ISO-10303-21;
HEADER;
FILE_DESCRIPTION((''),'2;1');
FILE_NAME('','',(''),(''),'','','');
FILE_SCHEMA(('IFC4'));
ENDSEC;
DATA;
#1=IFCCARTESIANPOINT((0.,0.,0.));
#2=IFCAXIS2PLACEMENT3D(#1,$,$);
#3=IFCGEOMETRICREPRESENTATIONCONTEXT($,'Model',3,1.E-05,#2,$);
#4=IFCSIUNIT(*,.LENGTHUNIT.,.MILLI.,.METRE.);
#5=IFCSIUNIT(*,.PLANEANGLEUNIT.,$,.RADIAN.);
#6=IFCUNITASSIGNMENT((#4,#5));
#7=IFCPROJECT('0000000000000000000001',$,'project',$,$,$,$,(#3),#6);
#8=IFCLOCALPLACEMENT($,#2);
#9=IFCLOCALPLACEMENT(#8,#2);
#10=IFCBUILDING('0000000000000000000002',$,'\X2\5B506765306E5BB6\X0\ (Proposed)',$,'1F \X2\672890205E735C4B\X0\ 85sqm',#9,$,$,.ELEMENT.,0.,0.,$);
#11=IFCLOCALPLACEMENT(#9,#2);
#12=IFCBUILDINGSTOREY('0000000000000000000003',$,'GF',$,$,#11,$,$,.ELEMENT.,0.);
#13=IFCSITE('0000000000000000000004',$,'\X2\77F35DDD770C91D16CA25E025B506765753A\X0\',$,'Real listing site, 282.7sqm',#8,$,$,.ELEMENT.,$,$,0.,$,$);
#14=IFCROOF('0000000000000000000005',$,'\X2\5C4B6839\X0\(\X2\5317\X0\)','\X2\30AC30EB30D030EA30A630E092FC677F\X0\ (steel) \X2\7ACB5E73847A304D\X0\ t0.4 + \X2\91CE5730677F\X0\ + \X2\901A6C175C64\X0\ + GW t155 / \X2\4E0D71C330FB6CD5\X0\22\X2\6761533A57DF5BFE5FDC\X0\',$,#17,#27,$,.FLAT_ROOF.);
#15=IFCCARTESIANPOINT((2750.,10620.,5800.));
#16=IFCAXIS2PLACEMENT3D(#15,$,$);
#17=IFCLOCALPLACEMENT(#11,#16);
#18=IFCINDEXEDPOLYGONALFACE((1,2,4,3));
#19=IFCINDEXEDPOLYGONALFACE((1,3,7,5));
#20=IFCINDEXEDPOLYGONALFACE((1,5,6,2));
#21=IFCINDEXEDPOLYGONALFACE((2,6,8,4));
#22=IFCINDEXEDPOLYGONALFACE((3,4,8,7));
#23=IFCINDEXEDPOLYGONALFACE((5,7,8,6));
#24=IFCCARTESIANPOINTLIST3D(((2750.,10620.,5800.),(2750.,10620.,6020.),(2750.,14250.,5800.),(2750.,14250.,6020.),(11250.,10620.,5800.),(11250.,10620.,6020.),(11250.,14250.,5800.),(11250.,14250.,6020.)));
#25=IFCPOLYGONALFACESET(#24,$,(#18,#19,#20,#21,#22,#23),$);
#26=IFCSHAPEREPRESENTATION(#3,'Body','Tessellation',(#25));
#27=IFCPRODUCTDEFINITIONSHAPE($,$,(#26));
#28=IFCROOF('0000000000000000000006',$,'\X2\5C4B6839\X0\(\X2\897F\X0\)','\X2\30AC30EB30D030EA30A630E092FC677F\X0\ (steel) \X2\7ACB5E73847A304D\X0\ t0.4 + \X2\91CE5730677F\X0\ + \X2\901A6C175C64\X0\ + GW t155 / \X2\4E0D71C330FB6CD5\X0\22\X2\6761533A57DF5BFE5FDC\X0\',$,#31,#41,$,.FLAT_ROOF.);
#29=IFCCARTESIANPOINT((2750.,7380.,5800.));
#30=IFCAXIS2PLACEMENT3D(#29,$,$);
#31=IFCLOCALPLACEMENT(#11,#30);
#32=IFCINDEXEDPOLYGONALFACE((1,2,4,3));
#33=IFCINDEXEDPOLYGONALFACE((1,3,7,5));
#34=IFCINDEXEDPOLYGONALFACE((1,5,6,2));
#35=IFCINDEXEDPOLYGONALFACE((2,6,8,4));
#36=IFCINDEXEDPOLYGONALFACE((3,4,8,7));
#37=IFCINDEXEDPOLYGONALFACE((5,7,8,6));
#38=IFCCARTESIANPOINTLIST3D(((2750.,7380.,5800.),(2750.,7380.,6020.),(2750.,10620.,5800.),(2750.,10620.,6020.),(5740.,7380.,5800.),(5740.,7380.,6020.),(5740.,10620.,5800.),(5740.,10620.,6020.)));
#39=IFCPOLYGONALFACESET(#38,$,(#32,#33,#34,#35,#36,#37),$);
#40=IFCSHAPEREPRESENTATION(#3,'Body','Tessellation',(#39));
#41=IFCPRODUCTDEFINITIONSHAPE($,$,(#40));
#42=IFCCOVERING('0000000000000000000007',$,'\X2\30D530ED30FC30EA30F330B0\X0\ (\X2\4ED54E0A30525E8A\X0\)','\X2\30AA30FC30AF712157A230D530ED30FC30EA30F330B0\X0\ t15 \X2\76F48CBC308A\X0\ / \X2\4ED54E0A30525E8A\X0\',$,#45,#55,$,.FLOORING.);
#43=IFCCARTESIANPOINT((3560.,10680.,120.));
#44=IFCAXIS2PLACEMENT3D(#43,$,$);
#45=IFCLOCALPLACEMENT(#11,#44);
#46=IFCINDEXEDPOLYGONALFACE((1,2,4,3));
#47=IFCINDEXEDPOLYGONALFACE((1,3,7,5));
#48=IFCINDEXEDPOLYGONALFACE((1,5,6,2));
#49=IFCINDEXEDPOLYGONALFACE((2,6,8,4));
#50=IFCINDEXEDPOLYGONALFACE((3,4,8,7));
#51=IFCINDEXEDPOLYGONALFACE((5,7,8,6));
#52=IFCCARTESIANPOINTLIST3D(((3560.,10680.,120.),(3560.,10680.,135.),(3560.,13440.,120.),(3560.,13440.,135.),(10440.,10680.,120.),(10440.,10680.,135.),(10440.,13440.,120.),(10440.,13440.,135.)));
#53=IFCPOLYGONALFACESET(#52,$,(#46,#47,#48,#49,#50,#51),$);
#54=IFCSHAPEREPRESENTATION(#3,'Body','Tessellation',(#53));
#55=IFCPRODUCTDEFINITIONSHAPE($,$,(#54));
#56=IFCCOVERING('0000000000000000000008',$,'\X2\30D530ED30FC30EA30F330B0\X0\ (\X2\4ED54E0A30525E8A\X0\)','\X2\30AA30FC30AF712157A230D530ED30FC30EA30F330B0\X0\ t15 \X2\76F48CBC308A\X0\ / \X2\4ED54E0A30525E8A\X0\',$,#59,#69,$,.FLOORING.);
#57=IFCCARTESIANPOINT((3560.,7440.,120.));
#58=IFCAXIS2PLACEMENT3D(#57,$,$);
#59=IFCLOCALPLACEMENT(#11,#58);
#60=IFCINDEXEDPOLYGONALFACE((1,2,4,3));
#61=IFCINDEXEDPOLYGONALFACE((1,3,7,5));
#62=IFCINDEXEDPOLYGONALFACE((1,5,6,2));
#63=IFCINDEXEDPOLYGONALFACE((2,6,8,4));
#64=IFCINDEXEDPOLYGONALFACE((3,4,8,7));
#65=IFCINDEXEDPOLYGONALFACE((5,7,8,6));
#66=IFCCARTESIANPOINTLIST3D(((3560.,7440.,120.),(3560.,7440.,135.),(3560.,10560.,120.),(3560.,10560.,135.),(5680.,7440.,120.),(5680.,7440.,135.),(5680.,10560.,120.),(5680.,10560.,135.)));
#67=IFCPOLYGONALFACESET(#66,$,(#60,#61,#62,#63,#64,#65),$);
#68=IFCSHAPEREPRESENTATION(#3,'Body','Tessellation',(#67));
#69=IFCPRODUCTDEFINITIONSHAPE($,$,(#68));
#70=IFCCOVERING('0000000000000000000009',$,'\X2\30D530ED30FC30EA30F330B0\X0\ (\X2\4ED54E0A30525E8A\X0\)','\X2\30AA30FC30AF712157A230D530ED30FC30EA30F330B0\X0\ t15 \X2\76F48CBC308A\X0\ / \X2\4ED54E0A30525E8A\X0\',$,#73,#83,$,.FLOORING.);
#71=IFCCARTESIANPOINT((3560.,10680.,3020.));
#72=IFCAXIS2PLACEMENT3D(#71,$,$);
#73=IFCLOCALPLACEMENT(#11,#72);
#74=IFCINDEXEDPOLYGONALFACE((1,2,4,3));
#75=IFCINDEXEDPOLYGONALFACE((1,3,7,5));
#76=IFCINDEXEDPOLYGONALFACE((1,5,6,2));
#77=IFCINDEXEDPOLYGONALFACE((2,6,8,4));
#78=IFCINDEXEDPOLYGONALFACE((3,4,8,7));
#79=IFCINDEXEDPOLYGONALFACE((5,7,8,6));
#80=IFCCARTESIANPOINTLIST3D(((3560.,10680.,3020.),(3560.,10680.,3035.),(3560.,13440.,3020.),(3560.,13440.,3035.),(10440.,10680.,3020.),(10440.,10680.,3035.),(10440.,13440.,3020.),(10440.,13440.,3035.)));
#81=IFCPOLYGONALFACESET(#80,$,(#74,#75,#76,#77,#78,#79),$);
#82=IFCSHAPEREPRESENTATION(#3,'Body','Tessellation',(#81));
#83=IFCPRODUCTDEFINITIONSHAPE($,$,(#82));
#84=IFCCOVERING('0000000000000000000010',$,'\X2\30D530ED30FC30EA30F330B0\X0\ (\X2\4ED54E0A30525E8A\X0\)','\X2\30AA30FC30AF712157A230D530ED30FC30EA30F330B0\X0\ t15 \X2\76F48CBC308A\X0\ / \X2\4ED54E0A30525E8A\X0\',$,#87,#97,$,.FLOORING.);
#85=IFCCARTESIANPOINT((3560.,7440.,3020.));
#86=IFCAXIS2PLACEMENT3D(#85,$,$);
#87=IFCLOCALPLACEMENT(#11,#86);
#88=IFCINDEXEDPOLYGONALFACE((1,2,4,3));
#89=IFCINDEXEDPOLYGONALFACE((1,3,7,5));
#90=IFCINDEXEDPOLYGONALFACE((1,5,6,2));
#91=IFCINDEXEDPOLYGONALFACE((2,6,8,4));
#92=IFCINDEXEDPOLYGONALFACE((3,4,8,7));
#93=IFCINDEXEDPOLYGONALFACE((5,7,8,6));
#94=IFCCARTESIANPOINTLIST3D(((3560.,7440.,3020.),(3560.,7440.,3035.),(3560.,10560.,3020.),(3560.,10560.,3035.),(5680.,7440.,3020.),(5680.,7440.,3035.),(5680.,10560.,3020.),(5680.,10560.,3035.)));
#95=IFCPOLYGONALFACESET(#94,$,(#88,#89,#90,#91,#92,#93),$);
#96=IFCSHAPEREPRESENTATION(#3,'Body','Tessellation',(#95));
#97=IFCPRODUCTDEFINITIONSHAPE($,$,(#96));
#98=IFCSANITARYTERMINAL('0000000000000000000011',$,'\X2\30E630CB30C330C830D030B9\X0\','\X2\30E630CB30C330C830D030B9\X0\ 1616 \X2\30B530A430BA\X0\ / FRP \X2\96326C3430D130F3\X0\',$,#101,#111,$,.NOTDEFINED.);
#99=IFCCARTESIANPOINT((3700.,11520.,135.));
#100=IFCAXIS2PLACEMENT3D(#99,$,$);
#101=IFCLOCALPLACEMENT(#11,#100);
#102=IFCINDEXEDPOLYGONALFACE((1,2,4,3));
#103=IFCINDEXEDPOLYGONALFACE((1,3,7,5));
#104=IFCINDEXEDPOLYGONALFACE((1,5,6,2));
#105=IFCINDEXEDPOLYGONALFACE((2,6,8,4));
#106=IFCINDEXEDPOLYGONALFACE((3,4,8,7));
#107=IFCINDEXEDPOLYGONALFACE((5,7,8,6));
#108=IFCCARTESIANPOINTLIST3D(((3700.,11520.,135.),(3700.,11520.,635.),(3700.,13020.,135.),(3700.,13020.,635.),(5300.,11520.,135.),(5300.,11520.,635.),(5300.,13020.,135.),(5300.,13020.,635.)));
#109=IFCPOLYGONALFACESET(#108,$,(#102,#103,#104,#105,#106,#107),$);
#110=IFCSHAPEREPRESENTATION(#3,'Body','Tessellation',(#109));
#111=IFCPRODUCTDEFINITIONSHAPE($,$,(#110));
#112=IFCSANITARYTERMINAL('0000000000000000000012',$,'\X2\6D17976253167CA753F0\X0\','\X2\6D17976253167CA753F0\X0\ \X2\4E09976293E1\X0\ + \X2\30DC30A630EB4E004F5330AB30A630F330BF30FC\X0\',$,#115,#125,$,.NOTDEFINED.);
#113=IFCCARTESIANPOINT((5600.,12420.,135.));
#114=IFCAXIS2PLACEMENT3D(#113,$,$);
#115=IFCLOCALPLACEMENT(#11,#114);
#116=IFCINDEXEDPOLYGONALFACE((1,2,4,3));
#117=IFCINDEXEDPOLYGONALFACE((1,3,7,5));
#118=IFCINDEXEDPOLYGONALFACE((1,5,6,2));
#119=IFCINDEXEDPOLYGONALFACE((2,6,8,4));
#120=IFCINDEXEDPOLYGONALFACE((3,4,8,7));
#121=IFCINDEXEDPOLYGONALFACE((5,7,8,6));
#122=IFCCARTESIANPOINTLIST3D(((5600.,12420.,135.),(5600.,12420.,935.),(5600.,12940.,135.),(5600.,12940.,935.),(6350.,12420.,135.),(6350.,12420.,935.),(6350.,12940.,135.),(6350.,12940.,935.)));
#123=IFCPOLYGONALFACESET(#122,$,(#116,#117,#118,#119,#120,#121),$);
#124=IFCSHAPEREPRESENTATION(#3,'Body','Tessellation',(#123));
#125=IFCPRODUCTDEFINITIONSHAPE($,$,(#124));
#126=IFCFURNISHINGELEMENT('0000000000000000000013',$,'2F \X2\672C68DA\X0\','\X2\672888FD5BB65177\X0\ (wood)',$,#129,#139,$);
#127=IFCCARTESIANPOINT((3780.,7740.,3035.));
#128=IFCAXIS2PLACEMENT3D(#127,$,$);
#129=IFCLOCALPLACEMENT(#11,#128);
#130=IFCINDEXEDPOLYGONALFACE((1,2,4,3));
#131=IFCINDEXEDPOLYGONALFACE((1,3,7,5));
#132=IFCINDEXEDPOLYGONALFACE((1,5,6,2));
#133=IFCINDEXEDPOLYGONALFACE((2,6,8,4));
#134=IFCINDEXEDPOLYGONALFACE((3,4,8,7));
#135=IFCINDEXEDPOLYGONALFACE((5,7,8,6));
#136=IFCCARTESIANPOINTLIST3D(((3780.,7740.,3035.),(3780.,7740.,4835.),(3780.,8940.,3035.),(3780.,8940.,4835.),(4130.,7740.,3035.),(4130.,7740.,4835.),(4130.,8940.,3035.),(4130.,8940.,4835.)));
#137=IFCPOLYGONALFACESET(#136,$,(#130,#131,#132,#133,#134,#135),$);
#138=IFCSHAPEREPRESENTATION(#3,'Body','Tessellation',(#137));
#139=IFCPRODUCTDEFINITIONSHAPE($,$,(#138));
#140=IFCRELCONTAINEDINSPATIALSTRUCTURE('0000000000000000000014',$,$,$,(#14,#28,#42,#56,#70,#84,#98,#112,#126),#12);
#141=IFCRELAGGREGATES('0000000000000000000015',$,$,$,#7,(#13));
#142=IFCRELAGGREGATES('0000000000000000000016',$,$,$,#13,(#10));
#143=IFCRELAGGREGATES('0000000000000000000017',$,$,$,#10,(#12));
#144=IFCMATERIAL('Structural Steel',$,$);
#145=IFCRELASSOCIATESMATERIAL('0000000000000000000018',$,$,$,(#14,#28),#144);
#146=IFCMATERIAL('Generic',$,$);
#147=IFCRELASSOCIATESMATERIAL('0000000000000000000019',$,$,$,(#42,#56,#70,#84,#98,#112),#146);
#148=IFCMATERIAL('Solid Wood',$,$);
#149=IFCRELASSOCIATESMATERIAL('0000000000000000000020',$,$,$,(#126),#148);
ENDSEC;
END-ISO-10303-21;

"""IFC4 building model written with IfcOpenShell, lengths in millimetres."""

from ifc_helpers import new_model, si_unit, frame, frame_2d, origin, place, context, project, spatial, rectangle, extrude, material, element, save


model = new_model("IFC4")

# Units and contexts
model_context = context("Model", 3, precision=1e-05, world=origin())
ifc_project = project(units=[si_unit("LENGTHUNIT", "METRE", prefix="MILLI"), si_unit("PLANEANGLEUNIT", "RADIAN")], contexts=[model_context])

# Site, building, storey
site_placement = place(None, origin())
site = spatial("IfcSite", under=ifc_project, at=site_placement, Name="石川県金沢市子来町", ObjectType="Real listing site, 282.7sqm", CompositionType="ELEMENT", RefElevation=0.0)
building_placement = place(site_placement, origin())
building = spatial("IfcBuilding", under=site, at=building_placement, Name="子来の家 (Proposed)", ObjectType="1F 木造平屋 85sqm", CompositionType="ELEMENT", ElevationOfRefHeight=0.0, ElevationOfTerrain=0.0)
storey_placement = place(building_placement, origin())
storey = spatial("IfcBuildingStorey", under=building, at=storey_placement, Name="GF", CompositionType="ELEMENT", Elevation=0.0)

# Shared definitions
ifc_material_1 = material(Name="Solid Wood")

# Roofs
ifc_material_2 = material(Name="Structural Steel")
for number, where, name in (
    (1, (2750.0, 10620.0, 5800.0), "屋根(北)"),
):
    element("IfcRoof", number, at=place(storey_placement, frame(where)), inside=storey, material=ifc_material_2, Name=name, Description="ガルバリウム鋼板 (steel) 立平葺き t0.4 + 野地板 + 通気層 + GW t155 / 不燃・法22条区域対応", PredefinedType="FLAT_ROOF", context=model_context, shape_type="SweptSolid", body=[
        extrude(rectangle(XDim=8500.0, YDim=3630.0, at=frame_2d((4250.0, 1815.0))), frame((2750.0, 10620.0, 5800.0)), (0.0, 0.0, 1.0), 220.0),
    ])
roof_placement = place(storey_placement, frame((2750.0, 7380.0, 5800.0)))
element("IfcRoof", 2, at=roof_placement, inside=storey, material=ifc_material_2, Name="屋根(西)", Description="ガルバリウム鋼板 (steel) 立平葺き t0.4 + 野地板 + 通気層 + GW t155 / 不燃・法22条区域対応", PredefinedType="FLAT_ROOF", context=model_context, shape_type="SweptSolid", body=[
    extrude(rectangle(XDim=2990.0, YDim=3240.0, at=frame_2d((1495.0, 1620.0))), frame((2750.0, 7380.0, 5800.0)), (0.0, 0.0, 1.0), 220.0),
])

# Coverings
ifc_material_3 = material(Name="Generic")
covering_1_placement = place(storey_placement, frame((3560.0, 10680.0, 120.0)))
element("IfcCovering", 3, at=covering_1_placement, inside=storey, material=ifc_material_3, Name="フローリング (仕上げ床)", Description="オーク無垢フローリング t15 直貼り / 仕上げ床", PredefinedType="FLOORING", context=model_context, shape_type="SweptSolid", body=[
    extrude(rectangle(XDim=6880.0, YDim=2760.0, at=frame_2d((3440.0, 1380.0))), frame((3560.0, 10680.0, 120.0)), (0.0, 0.0, 1.0), 15.0),
])
covering_2_placement = place(storey_placement, frame((3560.0, 7440.0, 120.0)))
element("IfcCovering", 4, at=covering_2_placement, inside=storey, material=ifc_material_3, Name="フローリング (仕上げ床)", Description="オーク無垢フローリング t15 直貼り / 仕上げ床", PredefinedType="FLOORING", context=model_context, shape_type="SweptSolid", body=[
    extrude(rectangle(XDim=2120.0, YDim=3120.0, at=frame_2d((1060.0, 1560.0))), frame((3560.0, 7440.0, 120.0)), (0.0, 0.0, 1.0), 15.0),
])
covering_3_placement = place(storey_placement, frame((3560.0, 10680.0, 3020.0)))
element("IfcCovering", 5, at=covering_3_placement, inside=storey, material=ifc_material_3, Name="フローリング (仕上げ床)", Description="オーク無垢フローリング t15 直貼り / 仕上げ床", PredefinedType="FLOORING", context=model_context, shape_type="SweptSolid", body=[
    extrude(rectangle(XDim=6880.0, YDim=2760.0, at=frame_2d((3440.0, 1380.0))), frame((3560.0, 10680.0, 3020.0)), (0.0, 0.0, 1.0), 15.0),
])
covering_4_placement = place(storey_placement, frame((3560.0, 7440.0, 3020.0)))
element("IfcCovering", 6, at=covering_4_placement, inside=storey, material=ifc_material_3, Name="フローリング (仕上げ床)", Description="オーク無垢フローリング t15 直貼り / 仕上げ床", PredefinedType="FLOORING", context=model_context, shape_type="SweptSolid", body=[
    extrude(rectangle(XDim=2120.0, YDim=3120.0, at=frame_2d((1060.0, 1560.0))), frame((3560.0, 7440.0, 3020.0)), (0.0, 0.0, 1.0), 15.0),
])

# Sanitary terminals
sanitary_terminal_1_placement = place(storey_placement, frame((3700.0, 11520.0, 135.0)))
element("IfcSanitaryTerminal", 7, at=sanitary_terminal_1_placement, inside=storey, material=ifc_material_3, Name="ユニットバス", Description="ユニットバス 1616 サイズ / FRP 防水パン", PredefinedType="NOTDEFINED", context=model_context, shape_type="SweptSolid", body=[
    extrude(rectangle(XDim=1600.0, YDim=1500.0, at=frame_2d((800.0, 750.0))), frame((3700.0, 11520.0, 135.0)), (0.0, 0.0, 1.0), 500.0),
])
sanitary_terminal_2_placement = place(storey_placement, frame((5600.0, 12420.0, 135.0)))
element("IfcSanitaryTerminal", 8, at=sanitary_terminal_2_placement, inside=storey, material=ifc_material_3, Name="洗面化粧台", Description="洗面化粧台 三面鏡 + ボウル一体カウンター", PredefinedType="NOTDEFINED", context=model_context, shape_type="SweptSolid", body=[
    extrude(rectangle(XDim=750.0, YDim=520.0, at=frame_2d((375.0, 260.0))), frame((5600.0, 12420.0, 135.0)), (0.0, 0.0, 1.0), 800.0),
])

# Furnishing element
furnishing_placement = place(storey_placement, frame((3780.0, 7740.0, 3035.0)))
element("IfcFurnishingElement", 9, at=furnishing_placement, inside=storey, material=ifc_material_1, Name="2F 本棚", Description="木製家具 (wood)", context=model_context, shape_type="SweptSolid", body=[
    extrude(rectangle(XDim=350.0, YDim=1200.0, at=frame_2d((175.0, 600.0))), frame((3780.0, 7740.0, 3035.0)), (0.0, 0.0, 1.0), 1800.0),
])

save(model, "model.ifc")
